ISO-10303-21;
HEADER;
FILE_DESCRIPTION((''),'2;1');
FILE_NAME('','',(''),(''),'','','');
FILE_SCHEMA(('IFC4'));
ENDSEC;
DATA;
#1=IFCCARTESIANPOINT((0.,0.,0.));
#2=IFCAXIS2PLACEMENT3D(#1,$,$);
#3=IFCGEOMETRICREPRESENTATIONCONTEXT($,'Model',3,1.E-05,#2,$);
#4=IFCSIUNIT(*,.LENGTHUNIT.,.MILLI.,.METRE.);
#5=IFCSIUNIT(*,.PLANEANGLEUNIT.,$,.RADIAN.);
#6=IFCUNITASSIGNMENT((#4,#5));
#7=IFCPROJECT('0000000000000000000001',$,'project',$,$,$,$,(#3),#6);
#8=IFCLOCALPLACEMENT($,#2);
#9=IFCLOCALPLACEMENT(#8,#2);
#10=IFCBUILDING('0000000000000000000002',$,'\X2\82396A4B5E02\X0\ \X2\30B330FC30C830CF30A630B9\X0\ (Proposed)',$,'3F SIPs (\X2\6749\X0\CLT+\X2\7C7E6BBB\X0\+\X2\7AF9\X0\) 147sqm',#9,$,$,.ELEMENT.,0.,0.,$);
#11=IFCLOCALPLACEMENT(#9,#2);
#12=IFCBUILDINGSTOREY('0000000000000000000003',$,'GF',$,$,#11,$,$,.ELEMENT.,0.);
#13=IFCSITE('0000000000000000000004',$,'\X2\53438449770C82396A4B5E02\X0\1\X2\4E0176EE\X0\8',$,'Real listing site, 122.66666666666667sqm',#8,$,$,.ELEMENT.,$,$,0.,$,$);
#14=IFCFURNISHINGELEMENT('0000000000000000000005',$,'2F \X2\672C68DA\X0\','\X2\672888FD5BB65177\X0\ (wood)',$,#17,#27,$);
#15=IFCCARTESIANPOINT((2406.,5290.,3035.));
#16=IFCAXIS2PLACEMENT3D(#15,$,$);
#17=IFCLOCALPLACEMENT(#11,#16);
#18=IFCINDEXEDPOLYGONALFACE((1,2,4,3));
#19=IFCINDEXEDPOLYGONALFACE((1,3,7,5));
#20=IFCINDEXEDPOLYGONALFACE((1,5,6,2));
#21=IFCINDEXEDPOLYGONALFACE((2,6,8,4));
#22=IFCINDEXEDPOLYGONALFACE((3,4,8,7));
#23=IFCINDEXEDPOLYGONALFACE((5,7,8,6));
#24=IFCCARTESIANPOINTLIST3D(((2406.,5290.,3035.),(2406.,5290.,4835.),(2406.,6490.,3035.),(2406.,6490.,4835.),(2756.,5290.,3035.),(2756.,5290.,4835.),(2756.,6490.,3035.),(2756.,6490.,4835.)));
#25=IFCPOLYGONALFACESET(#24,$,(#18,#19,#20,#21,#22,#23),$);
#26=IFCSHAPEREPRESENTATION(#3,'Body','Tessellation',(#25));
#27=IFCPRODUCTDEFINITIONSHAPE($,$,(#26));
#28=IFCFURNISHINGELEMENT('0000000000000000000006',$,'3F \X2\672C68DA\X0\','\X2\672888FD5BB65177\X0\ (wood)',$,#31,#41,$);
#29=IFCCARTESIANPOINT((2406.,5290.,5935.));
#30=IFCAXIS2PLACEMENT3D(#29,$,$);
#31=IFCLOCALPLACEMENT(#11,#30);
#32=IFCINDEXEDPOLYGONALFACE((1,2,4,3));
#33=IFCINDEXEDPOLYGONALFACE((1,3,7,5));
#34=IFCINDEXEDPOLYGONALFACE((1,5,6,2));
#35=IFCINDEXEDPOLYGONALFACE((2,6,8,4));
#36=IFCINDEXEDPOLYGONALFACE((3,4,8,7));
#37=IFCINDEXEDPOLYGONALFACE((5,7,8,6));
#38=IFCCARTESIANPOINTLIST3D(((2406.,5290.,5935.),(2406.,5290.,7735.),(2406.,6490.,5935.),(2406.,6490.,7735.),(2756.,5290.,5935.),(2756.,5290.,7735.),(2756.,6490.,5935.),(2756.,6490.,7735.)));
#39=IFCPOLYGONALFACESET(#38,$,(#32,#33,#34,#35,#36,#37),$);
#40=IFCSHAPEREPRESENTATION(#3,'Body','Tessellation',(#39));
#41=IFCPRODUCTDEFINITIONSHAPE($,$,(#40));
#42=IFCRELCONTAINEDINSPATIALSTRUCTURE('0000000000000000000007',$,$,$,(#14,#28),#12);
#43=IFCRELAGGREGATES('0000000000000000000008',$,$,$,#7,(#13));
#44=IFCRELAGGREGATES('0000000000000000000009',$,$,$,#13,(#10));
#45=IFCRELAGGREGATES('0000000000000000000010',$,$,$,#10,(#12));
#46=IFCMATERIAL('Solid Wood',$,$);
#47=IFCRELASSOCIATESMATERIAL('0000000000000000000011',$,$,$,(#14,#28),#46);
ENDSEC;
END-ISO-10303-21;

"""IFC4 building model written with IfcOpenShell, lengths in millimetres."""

from ifc_helpers import new_model, si_unit, frame, frame_2d, origin, place, context, project, spatial, rectangle, extrude, material, element, save


model = new_model("IFC4")

# Units and contexts
model_context = context("Model", 3, precision=1e-05, world=origin())
ifc_project = project(units=[si_unit("LENGTHUNIT", "METRE", prefix="MILLI"), si_unit("PLANEANGLEUNIT", "RADIAN")], contexts=[model_context])

# Site, building, storey
site_placement = place(None, origin())
site = spatial("IfcSite", under=ifc_project, at=site_placement, Name="千葉県船橋市1丁目8", ObjectType="Real listing site, 122.66666666666667sqm", CompositionType="ELEMENT", RefElevation=0.0)
building_placement = place(site_placement, origin())
building = spatial("IfcBuilding", under=site, at=building_placement, Name="船橋市 コートハウス (Proposed)", ObjectType="3F SIPs (杉CLT+籾殻+竹) 147sqm", CompositionType="ELEMENT", ElevationOfRefHeight=0.0, ElevationOfTerrain=0.0)
storey_placement = place(building_placement, origin())
storey = spatial("IfcBuildingStorey", under=building, at=storey_placement, Name="GF", CompositionType="ELEMENT", Elevation=0.0)

# Shared definitions
ifc_material_1 = material(Name="Solid Wood")

# Furnishing elements
furnishing_1_placement = place(storey_placement, frame((2406.0, 5290.0, 3035.0)))
element("IfcFurnishingElement", 1, at=furnishing_1_placement, inside=storey, material=ifc_material_1, Name="2F 本棚", Description="木製家具 (wood)", context=model_context, shape_type="SweptSolid", body=[
    extrude(rectangle(XDim=350.0, YDim=1200.0, at=frame_2d((175.0, 600.0))), frame((2406.0, 5290.0, 3035.0)), (0.0, 0.0, 1.0), 1800.0),
])
furnishing_2_placement = place(storey_placement, frame((2406.0, 5290.0, 5935.0)))
element("IfcFurnishingElement", 2, at=furnishing_2_placement, inside=storey, material=ifc_material_1, Name="3F 本棚", Description="木製家具 (wood)", context=model_context, shape_type="SweptSolid", body=[
    extrude(rectangle(XDim=350.0, YDim=1200.0, at=frame_2d((175.0, 600.0))), frame((2406.0, 5290.0, 5935.0)), (0.0, 0.0, 1.0), 1800.0),
])

save(model, "model.ifc")
